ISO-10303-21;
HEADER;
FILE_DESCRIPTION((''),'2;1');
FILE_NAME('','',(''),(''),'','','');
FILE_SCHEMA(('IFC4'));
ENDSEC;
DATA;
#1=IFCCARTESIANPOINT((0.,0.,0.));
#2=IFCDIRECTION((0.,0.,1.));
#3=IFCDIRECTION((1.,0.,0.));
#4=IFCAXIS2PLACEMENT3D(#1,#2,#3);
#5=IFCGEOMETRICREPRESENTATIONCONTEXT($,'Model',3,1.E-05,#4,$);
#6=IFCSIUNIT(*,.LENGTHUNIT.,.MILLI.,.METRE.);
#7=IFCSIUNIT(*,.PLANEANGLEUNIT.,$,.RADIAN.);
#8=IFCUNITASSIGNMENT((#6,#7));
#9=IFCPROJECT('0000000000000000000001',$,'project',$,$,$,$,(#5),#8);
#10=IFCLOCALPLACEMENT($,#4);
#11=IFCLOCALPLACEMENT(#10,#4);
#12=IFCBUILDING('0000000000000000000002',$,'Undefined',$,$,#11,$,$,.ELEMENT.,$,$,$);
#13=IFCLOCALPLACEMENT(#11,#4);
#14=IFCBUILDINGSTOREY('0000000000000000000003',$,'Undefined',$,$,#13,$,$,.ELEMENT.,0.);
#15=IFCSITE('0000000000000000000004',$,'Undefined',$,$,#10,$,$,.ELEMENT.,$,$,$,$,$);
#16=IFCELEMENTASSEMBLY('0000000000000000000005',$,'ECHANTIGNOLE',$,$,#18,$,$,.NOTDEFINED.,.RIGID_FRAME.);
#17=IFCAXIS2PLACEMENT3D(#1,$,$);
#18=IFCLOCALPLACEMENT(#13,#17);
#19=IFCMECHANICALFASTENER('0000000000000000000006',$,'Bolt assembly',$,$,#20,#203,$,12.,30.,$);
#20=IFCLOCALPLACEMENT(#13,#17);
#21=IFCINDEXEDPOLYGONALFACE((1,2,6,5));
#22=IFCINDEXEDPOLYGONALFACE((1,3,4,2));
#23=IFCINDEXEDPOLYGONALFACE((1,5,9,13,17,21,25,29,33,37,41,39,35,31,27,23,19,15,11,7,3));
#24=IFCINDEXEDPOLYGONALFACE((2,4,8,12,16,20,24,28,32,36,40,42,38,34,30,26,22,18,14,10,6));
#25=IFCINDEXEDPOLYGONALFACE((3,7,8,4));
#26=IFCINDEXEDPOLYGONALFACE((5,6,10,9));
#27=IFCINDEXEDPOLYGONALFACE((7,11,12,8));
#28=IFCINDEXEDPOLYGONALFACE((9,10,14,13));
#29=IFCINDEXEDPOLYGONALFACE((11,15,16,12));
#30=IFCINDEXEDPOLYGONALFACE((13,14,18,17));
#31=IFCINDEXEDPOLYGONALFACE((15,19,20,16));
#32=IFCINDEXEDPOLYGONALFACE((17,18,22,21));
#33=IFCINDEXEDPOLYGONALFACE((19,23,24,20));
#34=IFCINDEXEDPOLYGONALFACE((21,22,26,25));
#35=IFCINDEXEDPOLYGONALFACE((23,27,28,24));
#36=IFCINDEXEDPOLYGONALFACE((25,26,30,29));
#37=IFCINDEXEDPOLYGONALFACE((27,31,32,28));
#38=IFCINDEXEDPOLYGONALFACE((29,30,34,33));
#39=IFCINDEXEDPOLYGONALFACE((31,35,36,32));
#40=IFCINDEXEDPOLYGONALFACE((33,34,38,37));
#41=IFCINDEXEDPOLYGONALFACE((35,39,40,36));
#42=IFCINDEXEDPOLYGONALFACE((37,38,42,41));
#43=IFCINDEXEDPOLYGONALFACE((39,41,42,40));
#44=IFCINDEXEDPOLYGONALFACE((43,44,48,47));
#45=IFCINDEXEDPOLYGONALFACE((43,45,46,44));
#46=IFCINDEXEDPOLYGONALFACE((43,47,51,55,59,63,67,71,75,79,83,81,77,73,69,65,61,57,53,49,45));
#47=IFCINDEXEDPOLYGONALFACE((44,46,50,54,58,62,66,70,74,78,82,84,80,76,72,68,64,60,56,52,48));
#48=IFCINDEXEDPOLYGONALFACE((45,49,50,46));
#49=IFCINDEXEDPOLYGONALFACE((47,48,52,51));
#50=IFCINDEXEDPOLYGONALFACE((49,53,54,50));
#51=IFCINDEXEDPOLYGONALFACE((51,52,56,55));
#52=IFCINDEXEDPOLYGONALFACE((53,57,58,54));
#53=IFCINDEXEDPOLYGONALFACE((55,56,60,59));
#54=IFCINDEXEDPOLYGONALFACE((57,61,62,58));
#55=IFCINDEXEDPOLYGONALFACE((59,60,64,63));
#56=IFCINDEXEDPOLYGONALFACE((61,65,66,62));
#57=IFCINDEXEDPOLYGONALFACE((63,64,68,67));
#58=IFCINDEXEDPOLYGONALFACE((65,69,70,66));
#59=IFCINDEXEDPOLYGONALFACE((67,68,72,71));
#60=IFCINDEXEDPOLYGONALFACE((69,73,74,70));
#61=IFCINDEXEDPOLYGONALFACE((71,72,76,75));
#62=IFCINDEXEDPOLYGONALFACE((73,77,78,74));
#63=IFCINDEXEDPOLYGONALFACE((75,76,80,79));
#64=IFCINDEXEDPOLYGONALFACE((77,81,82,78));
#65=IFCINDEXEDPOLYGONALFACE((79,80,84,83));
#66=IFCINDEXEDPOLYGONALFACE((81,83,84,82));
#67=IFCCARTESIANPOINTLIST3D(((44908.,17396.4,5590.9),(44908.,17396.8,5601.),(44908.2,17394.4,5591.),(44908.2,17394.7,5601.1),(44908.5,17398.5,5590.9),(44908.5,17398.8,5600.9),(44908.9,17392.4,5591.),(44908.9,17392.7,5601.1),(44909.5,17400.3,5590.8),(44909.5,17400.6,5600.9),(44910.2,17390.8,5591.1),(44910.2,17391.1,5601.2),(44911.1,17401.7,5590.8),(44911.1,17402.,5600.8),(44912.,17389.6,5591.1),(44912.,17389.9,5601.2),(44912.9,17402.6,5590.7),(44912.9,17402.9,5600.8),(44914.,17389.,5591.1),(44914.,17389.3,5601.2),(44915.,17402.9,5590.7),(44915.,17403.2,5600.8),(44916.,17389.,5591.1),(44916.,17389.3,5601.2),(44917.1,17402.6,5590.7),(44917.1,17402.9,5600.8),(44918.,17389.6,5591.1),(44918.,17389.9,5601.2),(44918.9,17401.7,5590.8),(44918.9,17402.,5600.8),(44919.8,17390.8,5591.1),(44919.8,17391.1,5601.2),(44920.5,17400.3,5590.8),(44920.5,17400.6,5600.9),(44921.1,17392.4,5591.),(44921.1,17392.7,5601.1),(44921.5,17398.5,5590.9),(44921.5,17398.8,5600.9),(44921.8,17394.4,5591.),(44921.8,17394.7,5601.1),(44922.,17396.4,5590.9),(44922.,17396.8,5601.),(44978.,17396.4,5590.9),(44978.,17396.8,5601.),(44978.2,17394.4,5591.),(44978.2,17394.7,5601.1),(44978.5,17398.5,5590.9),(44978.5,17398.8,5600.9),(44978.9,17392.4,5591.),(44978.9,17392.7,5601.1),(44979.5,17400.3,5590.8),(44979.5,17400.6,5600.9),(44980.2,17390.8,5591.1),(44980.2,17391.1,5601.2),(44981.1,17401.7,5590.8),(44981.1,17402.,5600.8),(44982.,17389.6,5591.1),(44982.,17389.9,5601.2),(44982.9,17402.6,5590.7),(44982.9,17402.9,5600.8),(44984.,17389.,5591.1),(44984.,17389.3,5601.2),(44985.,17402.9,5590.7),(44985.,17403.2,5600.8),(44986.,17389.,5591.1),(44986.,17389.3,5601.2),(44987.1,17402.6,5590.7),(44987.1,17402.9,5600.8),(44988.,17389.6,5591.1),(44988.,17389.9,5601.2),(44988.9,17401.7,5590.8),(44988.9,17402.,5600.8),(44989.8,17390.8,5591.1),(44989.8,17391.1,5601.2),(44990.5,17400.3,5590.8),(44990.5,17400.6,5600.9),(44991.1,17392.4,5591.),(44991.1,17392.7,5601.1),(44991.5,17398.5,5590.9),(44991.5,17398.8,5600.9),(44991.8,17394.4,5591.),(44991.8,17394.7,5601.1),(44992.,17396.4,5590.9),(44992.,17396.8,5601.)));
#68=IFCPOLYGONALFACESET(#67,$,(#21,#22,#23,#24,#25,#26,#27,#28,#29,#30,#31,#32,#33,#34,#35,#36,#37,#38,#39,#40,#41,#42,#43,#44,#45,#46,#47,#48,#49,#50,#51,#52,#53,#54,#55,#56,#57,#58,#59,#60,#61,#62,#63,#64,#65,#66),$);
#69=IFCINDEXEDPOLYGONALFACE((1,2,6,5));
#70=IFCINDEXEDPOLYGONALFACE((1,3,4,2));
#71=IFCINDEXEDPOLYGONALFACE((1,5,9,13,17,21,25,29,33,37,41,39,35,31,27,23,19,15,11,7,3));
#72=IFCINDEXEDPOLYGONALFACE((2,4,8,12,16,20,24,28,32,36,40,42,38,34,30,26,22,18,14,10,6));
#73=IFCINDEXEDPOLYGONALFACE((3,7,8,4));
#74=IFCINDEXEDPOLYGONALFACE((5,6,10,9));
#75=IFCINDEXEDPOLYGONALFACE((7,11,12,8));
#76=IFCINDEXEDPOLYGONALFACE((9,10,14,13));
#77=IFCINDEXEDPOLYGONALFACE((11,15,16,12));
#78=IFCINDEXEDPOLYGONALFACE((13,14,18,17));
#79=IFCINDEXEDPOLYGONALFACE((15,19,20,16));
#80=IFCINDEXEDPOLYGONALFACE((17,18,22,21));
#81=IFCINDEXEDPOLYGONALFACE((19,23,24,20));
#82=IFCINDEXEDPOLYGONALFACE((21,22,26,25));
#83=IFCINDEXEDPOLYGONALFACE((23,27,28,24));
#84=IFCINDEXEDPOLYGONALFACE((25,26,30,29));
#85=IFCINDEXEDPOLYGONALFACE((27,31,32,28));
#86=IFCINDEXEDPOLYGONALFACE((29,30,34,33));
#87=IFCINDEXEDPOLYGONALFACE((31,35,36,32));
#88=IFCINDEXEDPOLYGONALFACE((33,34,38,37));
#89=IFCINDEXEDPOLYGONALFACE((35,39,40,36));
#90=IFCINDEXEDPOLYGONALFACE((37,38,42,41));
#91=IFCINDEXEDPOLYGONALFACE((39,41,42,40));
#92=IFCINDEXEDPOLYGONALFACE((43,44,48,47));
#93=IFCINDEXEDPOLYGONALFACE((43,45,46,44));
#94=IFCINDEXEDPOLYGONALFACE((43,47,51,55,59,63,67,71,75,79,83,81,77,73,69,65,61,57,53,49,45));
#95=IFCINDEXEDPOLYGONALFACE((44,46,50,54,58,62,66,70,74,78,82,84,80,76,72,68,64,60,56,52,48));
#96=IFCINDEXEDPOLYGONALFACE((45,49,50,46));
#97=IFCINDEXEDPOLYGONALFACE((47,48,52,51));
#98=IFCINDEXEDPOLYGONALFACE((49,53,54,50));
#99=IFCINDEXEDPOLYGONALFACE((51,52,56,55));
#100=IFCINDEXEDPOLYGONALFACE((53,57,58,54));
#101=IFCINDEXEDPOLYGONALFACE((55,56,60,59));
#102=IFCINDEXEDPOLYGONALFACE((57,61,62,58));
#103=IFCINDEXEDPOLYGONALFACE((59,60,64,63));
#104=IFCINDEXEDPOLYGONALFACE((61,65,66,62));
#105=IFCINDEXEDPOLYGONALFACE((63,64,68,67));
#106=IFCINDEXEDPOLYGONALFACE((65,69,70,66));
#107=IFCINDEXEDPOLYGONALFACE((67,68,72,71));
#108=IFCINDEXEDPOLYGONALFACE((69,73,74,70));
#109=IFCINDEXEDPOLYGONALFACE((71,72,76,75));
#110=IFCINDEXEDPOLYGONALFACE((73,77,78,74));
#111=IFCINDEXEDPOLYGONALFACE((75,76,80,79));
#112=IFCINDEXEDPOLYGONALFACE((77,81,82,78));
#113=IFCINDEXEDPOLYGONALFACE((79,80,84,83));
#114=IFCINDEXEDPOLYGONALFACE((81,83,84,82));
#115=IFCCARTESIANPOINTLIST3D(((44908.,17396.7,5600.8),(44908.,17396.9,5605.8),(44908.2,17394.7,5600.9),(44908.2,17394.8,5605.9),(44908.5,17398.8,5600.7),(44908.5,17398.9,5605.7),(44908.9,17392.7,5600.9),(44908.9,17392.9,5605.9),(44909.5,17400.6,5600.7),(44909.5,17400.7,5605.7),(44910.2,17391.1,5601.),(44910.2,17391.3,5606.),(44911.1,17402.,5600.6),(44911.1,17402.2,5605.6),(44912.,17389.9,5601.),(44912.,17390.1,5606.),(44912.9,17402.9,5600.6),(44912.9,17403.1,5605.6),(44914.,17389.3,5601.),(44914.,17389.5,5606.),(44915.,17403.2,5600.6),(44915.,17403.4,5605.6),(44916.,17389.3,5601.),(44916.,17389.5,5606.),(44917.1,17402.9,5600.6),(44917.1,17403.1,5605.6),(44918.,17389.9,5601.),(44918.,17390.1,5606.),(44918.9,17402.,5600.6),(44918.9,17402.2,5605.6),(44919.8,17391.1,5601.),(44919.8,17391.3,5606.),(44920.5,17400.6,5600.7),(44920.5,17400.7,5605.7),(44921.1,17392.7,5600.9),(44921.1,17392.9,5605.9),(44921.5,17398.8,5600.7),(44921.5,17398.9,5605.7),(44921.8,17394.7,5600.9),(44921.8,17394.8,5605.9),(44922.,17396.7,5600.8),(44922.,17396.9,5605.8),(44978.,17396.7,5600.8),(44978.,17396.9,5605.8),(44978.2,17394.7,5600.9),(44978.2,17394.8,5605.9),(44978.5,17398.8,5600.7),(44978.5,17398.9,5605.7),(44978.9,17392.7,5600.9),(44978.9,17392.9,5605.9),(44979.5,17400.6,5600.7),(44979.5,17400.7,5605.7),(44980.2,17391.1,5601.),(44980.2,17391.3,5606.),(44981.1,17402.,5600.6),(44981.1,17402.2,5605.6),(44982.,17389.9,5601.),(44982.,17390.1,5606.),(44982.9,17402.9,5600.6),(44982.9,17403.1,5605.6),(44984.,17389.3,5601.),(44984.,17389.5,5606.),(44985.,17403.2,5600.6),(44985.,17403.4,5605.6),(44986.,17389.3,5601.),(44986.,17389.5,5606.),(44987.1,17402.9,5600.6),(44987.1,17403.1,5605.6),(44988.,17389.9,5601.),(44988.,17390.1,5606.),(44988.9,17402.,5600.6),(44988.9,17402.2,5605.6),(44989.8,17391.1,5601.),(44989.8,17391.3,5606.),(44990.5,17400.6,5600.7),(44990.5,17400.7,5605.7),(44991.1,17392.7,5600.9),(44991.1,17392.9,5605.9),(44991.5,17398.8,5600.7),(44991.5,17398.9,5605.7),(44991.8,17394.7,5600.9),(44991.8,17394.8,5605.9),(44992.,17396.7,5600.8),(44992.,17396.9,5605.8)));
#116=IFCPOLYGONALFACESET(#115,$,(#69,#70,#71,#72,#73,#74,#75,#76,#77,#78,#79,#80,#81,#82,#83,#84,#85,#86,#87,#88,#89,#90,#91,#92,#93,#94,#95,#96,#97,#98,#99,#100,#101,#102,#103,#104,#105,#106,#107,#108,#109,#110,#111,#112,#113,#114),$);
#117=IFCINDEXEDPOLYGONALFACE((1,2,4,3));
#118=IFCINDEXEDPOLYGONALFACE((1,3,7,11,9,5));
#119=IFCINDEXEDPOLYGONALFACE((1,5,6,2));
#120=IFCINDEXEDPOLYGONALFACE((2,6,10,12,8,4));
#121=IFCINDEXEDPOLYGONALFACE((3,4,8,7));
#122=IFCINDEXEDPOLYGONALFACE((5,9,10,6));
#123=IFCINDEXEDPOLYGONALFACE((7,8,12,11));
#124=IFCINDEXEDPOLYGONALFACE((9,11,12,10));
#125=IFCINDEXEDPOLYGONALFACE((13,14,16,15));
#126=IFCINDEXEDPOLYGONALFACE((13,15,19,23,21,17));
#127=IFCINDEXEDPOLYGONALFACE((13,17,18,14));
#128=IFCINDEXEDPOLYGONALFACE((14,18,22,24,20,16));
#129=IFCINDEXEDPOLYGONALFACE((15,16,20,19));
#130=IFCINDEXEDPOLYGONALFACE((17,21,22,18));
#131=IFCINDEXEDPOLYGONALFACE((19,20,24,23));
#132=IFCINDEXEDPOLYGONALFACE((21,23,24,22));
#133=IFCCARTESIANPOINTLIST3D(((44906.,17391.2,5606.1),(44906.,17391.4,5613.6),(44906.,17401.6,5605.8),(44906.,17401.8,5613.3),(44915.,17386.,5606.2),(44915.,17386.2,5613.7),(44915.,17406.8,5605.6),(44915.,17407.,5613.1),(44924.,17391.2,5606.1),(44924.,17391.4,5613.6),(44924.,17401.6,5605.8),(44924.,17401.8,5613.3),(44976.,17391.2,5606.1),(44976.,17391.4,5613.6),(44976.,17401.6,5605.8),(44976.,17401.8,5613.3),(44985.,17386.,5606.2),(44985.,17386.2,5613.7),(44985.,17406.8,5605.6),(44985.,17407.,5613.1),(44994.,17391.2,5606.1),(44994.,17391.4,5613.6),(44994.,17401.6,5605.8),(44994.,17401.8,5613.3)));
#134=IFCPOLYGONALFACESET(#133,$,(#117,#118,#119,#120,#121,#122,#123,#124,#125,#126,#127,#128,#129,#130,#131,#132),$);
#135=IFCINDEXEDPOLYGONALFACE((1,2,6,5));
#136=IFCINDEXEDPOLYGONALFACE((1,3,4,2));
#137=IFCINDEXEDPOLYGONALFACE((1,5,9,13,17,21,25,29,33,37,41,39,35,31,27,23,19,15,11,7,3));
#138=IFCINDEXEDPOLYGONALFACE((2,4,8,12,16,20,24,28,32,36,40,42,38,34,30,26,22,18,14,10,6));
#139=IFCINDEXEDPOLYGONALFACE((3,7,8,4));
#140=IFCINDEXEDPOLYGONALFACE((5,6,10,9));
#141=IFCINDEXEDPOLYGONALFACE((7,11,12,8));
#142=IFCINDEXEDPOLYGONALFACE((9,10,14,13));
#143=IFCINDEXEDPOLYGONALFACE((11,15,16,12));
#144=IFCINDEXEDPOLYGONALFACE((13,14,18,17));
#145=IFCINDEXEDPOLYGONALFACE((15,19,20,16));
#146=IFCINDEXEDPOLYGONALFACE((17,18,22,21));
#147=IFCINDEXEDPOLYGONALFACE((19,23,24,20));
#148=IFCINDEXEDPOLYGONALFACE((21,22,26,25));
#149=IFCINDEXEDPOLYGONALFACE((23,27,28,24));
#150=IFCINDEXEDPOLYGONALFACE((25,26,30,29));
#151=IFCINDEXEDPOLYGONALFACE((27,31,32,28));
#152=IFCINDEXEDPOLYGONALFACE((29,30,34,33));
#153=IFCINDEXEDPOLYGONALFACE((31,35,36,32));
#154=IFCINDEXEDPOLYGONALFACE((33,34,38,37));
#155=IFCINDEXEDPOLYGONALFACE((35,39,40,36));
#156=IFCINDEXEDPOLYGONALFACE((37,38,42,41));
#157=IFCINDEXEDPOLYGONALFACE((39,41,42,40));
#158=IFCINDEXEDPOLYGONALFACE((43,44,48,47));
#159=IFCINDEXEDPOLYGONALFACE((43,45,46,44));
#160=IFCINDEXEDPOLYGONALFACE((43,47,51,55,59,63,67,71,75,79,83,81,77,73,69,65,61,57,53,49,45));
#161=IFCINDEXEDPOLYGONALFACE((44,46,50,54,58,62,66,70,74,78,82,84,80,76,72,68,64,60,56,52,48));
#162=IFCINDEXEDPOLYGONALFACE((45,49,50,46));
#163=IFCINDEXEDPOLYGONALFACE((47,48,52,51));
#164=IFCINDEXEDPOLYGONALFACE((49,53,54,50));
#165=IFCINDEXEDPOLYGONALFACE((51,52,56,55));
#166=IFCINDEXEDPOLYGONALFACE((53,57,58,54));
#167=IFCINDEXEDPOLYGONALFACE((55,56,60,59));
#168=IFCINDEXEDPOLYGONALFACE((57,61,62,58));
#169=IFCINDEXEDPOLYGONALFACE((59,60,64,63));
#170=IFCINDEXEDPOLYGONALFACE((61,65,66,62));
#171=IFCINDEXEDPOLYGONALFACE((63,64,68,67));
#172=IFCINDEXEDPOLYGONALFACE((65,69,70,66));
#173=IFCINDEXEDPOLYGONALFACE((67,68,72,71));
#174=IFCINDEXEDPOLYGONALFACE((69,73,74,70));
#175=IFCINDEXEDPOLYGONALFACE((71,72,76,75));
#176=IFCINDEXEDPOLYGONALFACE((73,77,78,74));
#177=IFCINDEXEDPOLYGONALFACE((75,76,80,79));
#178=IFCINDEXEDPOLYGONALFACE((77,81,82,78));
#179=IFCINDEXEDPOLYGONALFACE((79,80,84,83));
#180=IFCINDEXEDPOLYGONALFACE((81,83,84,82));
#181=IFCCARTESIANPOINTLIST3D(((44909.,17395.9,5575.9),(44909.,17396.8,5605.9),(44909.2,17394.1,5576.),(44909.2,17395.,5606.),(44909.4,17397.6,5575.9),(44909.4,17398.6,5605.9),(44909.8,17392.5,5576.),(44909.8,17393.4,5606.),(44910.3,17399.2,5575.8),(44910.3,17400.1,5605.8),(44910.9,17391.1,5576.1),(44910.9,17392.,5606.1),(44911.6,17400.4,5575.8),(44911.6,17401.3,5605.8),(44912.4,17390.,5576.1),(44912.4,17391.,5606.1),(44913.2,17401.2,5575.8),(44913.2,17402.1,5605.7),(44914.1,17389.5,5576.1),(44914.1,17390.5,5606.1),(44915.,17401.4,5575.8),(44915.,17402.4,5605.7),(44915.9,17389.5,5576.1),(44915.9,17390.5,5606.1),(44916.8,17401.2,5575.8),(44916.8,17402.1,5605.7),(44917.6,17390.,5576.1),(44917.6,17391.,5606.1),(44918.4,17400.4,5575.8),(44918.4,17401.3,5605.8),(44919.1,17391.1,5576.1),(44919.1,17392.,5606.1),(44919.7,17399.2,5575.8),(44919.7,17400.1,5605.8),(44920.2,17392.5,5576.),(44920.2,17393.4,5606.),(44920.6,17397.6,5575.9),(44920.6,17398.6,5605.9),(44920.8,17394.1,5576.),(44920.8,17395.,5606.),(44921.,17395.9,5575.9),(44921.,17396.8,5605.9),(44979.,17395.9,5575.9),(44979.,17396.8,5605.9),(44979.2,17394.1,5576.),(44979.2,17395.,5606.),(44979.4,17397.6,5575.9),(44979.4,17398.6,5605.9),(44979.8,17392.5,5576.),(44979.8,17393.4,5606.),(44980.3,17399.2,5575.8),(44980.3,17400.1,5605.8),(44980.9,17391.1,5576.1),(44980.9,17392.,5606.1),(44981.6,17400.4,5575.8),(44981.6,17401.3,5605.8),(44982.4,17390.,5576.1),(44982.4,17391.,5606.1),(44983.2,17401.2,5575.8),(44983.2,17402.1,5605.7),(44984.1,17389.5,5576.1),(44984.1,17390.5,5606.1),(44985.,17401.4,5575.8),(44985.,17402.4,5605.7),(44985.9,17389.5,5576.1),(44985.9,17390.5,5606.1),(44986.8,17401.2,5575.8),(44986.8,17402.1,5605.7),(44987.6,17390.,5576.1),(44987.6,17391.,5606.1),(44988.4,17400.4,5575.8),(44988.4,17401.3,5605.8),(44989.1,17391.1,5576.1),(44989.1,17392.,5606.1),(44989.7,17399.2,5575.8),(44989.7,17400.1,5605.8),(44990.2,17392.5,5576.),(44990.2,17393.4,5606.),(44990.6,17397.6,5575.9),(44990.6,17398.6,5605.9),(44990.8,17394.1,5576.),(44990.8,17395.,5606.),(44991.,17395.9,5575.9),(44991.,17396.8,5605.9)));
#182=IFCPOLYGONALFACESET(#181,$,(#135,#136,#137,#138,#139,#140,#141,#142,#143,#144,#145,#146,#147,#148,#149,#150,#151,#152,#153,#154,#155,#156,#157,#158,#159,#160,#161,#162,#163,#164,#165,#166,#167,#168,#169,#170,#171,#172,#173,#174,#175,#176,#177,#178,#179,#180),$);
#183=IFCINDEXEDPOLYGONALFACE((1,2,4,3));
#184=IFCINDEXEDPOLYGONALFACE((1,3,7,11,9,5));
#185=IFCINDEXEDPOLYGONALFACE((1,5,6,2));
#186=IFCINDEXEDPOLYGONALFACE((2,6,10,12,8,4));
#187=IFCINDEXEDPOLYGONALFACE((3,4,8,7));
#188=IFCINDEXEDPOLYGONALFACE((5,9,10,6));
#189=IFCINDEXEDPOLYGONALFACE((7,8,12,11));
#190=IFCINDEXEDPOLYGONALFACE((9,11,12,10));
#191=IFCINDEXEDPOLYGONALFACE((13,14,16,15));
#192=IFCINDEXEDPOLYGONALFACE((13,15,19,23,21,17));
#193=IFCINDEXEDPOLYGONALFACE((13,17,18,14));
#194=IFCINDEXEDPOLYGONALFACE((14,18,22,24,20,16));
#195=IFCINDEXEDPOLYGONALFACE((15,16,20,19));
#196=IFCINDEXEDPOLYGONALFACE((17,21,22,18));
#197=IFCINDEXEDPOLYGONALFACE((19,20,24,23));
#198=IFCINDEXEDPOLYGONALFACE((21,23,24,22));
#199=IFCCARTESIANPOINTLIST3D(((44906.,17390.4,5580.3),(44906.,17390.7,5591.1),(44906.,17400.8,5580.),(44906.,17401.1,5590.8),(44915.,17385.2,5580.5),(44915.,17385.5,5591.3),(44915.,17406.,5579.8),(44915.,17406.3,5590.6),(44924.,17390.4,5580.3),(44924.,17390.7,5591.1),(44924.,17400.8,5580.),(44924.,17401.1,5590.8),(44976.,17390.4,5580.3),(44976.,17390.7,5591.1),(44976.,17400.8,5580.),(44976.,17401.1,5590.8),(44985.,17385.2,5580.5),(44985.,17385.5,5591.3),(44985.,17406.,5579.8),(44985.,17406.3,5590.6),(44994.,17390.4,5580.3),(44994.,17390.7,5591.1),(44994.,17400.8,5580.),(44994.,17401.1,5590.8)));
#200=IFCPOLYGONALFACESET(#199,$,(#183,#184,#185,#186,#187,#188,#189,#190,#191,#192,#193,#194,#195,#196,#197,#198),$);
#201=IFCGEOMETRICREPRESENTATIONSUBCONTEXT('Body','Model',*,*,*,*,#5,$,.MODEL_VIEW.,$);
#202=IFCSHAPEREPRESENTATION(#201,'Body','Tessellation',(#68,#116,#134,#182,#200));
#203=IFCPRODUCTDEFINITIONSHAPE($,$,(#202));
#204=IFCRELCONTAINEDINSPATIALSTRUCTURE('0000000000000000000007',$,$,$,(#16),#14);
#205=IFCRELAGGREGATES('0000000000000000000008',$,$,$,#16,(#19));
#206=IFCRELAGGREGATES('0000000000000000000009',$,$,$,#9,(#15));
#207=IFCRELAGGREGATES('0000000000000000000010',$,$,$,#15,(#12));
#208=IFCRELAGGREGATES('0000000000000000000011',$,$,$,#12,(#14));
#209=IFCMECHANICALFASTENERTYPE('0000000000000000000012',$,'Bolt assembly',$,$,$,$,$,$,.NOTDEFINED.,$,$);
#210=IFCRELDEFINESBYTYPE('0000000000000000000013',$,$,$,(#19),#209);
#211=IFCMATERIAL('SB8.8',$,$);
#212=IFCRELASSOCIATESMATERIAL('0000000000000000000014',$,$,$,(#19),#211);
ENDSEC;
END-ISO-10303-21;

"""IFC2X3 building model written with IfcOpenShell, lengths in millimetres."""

from ifc_helpers import new_model, si_unit, frame, origin_with_axes, origin_2d_with_axis, place, context, subcontext, project, spatial, polyline, circle, outline, extrude, source, transform, mapped, material, type_object, element, aggregate, save


model = new_model("IFC2X3")

# Units and contexts
model_context = context("Model", 3, precision=1e-05, world=origin_with_axes())
body_context = subcontext(model_context, "Body", "Model", "MODEL_VIEW")
ifc_project = project(units=[si_unit("LENGTHUNIT", "METRE", prefix="MILLI"), si_unit("PLANEANGLEUNIT", "RADIAN")], contexts=[model_context])

# Site, building, storey
site_placement = place(None, origin_with_axes())
site = spatial("IfcSite", under=ifc_project, at=site_placement, Name="Undefined", CompositionType="ELEMENT")
building_placement = place(site_placement, origin_with_axes())
building = spatial("IfcBuilding", under=site, at=building_placement, Name="Undefined", CompositionType="ELEMENT")
storey_placement = place(building_placement, origin_with_axes())
storey = spatial("IfcBuildingStorey", under=building, at=storey_placement, Name="Undefined", CompositionType="ELEMENT", Elevation=0.0)

# Shared definitions
ifc_material_1 = material(Name="SB8.8")
mechanical_fastener_type = type_object("IfcMechanicalFastenerType", Name="Bolt assembly")

# Element assembly, mechanical fastener
assembly_1_placement = place(storey_placement, origin_with_axes())
assembly_1 = element("IfcElementAssembly", 1, at=assembly_1_placement, inside=storey, Name="ECHANTIGNOLE", AssemblyPlace="NOTDEFINED", PredefinedType="RIGID_FRAME")
shared_shape_1 = source(origin_with_axes(), body_context, "Body", "SweptSolid", [
    extrude(circle(Radius=7.0, at=origin_2d_with_axis()), frame((0.0, -0.1, 0.0), z_axis=(0.0, 1.0, 0.0), x_axis=(1.0, 0.0, 0.0)), (0.0, 0.0, 1.0), 10.1),
    extrude(circle(Radius=7.0, at=origin_2d_with_axis()), frame((0.0, -4.9, 0.0), z_axis=(0.0, 1.0, 0.0), x_axis=(1.0, 0.0, 0.0)), (0.0, 0.0, 1.0), 5.0),
    extrude(outline(polyline([(10.4, 0.0), (5.2, 9.0), (-5.2, 9.0), (-10.4, 0.0), (-5.2, -9.0), (5.2, -9.0), (10.4, 0.0)])), frame((0.0, -12.5, 0.0), z_axis=(0.0, 1.0, 0.0), x_axis=(1.0, 0.0, 0.0)), (0.0, 0.0, 1.0), 7.5),
    extrude(circle(Radius=6.0, at=origin_2d_with_axis()), frame((0.0, -5.0, 0.0), z_axis=(0.0, 1.0, 0.0), x_axis=(1.0, 0.0, 0.0)), (0.0, 0.0, 1.0), 30.0),
    extrude(outline(polyline([(10.4, 0.0), (5.2, 9.0), (-5.2, 9.0), (-10.4, 0.0), (-5.2, -9.0), (5.2, -9.0), (10.4, 0.0)])), frame((0.0, 10.0, 0.0), z_axis=(0.0, 1.0, 0.0), x_axis=(1.0, 0.0, 0.0)), (0.0, 0.0, 1.0), 10.8),
])
mechanical_fastener_1_placement = place(assembly_1_placement, frame((44950.0, 17396.2, 5600.9), z_axis=(-1.0, 0.0, 0.0), x_axis=(0.0, 0.99952, -0.030986)))
mechanical_fastener_1 = element("IfcMechanicalFastener", 2, at=mechanical_fastener_1_placement, type_object=mechanical_fastener_type, material=ifc_material_1, Name="Bolt assembly", NominalDiameter=12.0, NominalLength=30.0, context=body_context, shape_type="MappedRepresentation", body=[
    mapped(shared_shape_1, transform((0.0, 0.0, 35.0))),
    mapped(shared_shape_1, transform((0.0, 0.0, -35.0))),
])
aggregate(assembly_1, [mechanical_fastener_1])

save(model, "model.ifc")
